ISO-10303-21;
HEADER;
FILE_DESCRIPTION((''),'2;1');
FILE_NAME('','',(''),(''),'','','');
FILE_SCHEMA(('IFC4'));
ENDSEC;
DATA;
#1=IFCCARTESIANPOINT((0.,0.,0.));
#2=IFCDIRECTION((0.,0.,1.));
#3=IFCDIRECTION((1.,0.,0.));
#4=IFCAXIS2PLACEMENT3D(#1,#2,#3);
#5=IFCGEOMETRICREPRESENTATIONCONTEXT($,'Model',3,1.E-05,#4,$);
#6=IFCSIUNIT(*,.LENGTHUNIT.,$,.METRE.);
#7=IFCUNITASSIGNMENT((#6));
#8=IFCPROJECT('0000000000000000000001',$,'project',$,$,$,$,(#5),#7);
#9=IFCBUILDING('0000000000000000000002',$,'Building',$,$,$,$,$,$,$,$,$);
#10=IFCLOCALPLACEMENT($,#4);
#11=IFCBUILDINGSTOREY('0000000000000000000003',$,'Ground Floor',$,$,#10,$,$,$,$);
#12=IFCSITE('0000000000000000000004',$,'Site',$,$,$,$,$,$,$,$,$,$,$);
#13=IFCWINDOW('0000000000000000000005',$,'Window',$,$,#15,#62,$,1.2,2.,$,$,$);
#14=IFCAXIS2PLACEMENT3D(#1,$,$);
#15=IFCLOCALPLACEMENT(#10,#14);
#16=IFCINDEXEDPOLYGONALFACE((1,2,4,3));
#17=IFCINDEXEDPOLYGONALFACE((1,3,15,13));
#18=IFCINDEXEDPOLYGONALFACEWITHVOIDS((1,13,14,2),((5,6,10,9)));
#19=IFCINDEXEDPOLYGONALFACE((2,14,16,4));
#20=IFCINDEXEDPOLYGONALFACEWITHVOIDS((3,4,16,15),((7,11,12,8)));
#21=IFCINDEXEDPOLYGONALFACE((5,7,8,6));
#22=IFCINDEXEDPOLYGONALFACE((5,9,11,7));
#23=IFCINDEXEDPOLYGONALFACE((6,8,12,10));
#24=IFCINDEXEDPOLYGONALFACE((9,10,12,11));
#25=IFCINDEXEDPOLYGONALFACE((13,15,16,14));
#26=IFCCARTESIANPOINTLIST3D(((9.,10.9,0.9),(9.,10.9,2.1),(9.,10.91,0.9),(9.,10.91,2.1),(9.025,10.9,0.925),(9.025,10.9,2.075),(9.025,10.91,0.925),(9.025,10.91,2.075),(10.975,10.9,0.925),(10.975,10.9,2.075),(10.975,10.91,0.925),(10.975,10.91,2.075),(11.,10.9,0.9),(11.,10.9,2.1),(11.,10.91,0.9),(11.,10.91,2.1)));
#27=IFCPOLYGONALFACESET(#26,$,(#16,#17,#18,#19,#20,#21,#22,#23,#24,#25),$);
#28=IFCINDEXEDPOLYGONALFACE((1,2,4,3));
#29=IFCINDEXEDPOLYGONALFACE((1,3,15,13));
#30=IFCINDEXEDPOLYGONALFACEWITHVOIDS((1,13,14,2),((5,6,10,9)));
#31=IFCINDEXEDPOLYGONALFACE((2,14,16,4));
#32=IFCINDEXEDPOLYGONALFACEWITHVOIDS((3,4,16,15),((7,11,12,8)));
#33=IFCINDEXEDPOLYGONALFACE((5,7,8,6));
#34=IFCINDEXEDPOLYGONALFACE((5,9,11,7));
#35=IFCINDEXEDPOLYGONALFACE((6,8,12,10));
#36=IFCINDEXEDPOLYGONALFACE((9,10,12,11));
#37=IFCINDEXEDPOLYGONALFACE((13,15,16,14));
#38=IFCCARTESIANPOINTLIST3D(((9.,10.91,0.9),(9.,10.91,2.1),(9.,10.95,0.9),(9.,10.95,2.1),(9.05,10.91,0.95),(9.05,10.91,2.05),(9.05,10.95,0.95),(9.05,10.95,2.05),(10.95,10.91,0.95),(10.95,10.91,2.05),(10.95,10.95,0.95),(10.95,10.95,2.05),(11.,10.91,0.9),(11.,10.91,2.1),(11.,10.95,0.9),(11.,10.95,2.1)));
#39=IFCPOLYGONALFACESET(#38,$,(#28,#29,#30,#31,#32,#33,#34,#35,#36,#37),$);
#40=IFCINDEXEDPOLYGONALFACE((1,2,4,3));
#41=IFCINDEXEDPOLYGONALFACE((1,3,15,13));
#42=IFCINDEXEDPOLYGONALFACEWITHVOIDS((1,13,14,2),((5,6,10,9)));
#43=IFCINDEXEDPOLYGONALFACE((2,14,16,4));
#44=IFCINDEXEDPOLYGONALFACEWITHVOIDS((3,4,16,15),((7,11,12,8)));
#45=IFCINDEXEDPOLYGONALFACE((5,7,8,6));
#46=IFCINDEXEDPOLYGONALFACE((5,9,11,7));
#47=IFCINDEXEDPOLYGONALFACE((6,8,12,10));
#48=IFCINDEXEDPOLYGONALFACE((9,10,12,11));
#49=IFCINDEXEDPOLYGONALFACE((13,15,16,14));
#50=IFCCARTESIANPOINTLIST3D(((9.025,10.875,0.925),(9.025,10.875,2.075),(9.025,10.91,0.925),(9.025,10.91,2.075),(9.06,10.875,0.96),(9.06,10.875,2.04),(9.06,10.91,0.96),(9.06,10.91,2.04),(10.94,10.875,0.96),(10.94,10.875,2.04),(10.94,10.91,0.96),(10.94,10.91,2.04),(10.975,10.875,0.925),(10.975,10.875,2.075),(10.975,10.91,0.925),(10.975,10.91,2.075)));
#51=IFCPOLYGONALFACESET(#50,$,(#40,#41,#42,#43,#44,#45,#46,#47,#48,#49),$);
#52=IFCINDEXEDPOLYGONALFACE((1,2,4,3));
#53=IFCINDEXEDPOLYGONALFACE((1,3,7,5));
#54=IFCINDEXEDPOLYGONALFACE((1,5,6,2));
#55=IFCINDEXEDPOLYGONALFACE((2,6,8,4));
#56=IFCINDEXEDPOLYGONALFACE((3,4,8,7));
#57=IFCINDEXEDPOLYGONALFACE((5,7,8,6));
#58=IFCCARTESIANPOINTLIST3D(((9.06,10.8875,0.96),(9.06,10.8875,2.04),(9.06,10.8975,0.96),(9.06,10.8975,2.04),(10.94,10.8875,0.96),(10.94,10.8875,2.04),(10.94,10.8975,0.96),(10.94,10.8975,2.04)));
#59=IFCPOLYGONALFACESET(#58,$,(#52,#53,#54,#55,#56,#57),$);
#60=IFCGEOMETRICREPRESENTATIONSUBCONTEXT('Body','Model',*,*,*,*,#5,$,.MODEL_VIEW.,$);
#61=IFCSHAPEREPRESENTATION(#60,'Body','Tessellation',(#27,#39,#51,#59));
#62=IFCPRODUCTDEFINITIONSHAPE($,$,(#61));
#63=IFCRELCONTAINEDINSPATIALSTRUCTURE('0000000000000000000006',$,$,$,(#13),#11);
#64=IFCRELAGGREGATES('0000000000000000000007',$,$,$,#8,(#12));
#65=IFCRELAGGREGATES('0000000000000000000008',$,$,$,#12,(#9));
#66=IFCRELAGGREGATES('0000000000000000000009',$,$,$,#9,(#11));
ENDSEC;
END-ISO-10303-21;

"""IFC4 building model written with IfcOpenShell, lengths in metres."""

from ifc_helpers import new_model, si_unit, frame, origin_with_axes, place, context, subcontext, project, spatial, line, indexed_curve, outline, extrude, element, save


model = new_model("IFC4")

# Units and contexts
model_context = context("Model", 3, precision=1e-05, world=origin_with_axes())
body_context = subcontext(model_context, "Body", "Model", "MODEL_VIEW")
ifc_project = project(units=[si_unit("LENGTHUNIT", "METRE")], contexts=[model_context])

# Site, building, storey
site = spatial("IfcSite", under=ifc_project, Name="Site")
building = spatial("IfcBuilding", under=site, Name="Building")
storey_placement = place(None, origin_with_axes())
storey = spatial("IfcBuildingStorey", under=building, at=storey_placement, Name="Ground Floor")

# Window
window_1_placement = place(storey_placement, frame((11.0, 11.0, 0.9), z_axis=(0.0, 0.0, 1.0), x_axis=(-1.0, 0.0, 0.0)))
element("IfcWindow", 1, at=window_1_placement, inside=storey, Name="Window", OverallHeight=1.2, OverallWidth=2.0, context=body_context, shape_type="SweptSolid", body=[
    extrude(outline(indexed_curve([(0.0, 0.0), (2.0, 0.0), (2.0, 1.2), (0.0, 1.2)], segments=[line(1, 2, 3, 4, 1)]), holes=[indexed_curve([(0.025, 0.025), (1.975, 0.025), (1.975, 1.175), (0.025, 1.175)], segments=[line(1, 2, 3, 4, 1)])]), frame((0.0, 0.09, 0.0), z_axis=(0.0, -1.0, 0.0), x_axis=(1.0, 0.0, 0.0)), (0.0, 0.0, -1.0), 0.01),
    extrude(outline(indexed_curve([(0.0, 0.0), (2.0, 0.0), (2.0, 1.2), (0.0, 1.2)], segments=[line(1, 2, 3, 4, 1)]), holes=[indexed_curve([(0.05, 0.05), (1.95, 0.05), (1.95, 1.15), (0.05, 1.15)], segments=[line(1, 2, 3, 4, 1)])]), frame((0.0, 0.05, 0.0), z_axis=(0.0, -1.0, 0.0), x_axis=(1.0, 0.0, 0.0)), (0.0, 0.0, -1.0), 0.04),
    extrude(outline(indexed_curve([(0.0, 0.0), (1.95, 0.0), (1.95, 1.15), (0.0, 1.15)], segments=[line(1, 2, 3, 4, 1)]), holes=[indexed_curve([(0.035, 0.035), (1.915, 0.035), (1.915, 1.115), (0.035, 1.115)], segments=[line(1, 2, 3, 4, 1)])]), frame((0.025, 0.09, 0.025), z_axis=(0.0, -1.0, 0.0), x_axis=(1.0, 0.0, 0.0)), (0.0, 0.0, -1.0), 0.035),
    extrude(outline(indexed_curve([(0.035, 0.035), (1.915, 0.035), (1.915, 1.115), (0.035, 1.115)], segments=[line(1, 2, 3, 4, 1)])), frame((0.025, 0.1025, 0.025), z_axis=(0.0, -1.0, 0.0), x_axis=(1.0, 0.0, 0.0)), (0.0, 0.0, -1.0), 0.01),
])

save(model, "model.ifc")
